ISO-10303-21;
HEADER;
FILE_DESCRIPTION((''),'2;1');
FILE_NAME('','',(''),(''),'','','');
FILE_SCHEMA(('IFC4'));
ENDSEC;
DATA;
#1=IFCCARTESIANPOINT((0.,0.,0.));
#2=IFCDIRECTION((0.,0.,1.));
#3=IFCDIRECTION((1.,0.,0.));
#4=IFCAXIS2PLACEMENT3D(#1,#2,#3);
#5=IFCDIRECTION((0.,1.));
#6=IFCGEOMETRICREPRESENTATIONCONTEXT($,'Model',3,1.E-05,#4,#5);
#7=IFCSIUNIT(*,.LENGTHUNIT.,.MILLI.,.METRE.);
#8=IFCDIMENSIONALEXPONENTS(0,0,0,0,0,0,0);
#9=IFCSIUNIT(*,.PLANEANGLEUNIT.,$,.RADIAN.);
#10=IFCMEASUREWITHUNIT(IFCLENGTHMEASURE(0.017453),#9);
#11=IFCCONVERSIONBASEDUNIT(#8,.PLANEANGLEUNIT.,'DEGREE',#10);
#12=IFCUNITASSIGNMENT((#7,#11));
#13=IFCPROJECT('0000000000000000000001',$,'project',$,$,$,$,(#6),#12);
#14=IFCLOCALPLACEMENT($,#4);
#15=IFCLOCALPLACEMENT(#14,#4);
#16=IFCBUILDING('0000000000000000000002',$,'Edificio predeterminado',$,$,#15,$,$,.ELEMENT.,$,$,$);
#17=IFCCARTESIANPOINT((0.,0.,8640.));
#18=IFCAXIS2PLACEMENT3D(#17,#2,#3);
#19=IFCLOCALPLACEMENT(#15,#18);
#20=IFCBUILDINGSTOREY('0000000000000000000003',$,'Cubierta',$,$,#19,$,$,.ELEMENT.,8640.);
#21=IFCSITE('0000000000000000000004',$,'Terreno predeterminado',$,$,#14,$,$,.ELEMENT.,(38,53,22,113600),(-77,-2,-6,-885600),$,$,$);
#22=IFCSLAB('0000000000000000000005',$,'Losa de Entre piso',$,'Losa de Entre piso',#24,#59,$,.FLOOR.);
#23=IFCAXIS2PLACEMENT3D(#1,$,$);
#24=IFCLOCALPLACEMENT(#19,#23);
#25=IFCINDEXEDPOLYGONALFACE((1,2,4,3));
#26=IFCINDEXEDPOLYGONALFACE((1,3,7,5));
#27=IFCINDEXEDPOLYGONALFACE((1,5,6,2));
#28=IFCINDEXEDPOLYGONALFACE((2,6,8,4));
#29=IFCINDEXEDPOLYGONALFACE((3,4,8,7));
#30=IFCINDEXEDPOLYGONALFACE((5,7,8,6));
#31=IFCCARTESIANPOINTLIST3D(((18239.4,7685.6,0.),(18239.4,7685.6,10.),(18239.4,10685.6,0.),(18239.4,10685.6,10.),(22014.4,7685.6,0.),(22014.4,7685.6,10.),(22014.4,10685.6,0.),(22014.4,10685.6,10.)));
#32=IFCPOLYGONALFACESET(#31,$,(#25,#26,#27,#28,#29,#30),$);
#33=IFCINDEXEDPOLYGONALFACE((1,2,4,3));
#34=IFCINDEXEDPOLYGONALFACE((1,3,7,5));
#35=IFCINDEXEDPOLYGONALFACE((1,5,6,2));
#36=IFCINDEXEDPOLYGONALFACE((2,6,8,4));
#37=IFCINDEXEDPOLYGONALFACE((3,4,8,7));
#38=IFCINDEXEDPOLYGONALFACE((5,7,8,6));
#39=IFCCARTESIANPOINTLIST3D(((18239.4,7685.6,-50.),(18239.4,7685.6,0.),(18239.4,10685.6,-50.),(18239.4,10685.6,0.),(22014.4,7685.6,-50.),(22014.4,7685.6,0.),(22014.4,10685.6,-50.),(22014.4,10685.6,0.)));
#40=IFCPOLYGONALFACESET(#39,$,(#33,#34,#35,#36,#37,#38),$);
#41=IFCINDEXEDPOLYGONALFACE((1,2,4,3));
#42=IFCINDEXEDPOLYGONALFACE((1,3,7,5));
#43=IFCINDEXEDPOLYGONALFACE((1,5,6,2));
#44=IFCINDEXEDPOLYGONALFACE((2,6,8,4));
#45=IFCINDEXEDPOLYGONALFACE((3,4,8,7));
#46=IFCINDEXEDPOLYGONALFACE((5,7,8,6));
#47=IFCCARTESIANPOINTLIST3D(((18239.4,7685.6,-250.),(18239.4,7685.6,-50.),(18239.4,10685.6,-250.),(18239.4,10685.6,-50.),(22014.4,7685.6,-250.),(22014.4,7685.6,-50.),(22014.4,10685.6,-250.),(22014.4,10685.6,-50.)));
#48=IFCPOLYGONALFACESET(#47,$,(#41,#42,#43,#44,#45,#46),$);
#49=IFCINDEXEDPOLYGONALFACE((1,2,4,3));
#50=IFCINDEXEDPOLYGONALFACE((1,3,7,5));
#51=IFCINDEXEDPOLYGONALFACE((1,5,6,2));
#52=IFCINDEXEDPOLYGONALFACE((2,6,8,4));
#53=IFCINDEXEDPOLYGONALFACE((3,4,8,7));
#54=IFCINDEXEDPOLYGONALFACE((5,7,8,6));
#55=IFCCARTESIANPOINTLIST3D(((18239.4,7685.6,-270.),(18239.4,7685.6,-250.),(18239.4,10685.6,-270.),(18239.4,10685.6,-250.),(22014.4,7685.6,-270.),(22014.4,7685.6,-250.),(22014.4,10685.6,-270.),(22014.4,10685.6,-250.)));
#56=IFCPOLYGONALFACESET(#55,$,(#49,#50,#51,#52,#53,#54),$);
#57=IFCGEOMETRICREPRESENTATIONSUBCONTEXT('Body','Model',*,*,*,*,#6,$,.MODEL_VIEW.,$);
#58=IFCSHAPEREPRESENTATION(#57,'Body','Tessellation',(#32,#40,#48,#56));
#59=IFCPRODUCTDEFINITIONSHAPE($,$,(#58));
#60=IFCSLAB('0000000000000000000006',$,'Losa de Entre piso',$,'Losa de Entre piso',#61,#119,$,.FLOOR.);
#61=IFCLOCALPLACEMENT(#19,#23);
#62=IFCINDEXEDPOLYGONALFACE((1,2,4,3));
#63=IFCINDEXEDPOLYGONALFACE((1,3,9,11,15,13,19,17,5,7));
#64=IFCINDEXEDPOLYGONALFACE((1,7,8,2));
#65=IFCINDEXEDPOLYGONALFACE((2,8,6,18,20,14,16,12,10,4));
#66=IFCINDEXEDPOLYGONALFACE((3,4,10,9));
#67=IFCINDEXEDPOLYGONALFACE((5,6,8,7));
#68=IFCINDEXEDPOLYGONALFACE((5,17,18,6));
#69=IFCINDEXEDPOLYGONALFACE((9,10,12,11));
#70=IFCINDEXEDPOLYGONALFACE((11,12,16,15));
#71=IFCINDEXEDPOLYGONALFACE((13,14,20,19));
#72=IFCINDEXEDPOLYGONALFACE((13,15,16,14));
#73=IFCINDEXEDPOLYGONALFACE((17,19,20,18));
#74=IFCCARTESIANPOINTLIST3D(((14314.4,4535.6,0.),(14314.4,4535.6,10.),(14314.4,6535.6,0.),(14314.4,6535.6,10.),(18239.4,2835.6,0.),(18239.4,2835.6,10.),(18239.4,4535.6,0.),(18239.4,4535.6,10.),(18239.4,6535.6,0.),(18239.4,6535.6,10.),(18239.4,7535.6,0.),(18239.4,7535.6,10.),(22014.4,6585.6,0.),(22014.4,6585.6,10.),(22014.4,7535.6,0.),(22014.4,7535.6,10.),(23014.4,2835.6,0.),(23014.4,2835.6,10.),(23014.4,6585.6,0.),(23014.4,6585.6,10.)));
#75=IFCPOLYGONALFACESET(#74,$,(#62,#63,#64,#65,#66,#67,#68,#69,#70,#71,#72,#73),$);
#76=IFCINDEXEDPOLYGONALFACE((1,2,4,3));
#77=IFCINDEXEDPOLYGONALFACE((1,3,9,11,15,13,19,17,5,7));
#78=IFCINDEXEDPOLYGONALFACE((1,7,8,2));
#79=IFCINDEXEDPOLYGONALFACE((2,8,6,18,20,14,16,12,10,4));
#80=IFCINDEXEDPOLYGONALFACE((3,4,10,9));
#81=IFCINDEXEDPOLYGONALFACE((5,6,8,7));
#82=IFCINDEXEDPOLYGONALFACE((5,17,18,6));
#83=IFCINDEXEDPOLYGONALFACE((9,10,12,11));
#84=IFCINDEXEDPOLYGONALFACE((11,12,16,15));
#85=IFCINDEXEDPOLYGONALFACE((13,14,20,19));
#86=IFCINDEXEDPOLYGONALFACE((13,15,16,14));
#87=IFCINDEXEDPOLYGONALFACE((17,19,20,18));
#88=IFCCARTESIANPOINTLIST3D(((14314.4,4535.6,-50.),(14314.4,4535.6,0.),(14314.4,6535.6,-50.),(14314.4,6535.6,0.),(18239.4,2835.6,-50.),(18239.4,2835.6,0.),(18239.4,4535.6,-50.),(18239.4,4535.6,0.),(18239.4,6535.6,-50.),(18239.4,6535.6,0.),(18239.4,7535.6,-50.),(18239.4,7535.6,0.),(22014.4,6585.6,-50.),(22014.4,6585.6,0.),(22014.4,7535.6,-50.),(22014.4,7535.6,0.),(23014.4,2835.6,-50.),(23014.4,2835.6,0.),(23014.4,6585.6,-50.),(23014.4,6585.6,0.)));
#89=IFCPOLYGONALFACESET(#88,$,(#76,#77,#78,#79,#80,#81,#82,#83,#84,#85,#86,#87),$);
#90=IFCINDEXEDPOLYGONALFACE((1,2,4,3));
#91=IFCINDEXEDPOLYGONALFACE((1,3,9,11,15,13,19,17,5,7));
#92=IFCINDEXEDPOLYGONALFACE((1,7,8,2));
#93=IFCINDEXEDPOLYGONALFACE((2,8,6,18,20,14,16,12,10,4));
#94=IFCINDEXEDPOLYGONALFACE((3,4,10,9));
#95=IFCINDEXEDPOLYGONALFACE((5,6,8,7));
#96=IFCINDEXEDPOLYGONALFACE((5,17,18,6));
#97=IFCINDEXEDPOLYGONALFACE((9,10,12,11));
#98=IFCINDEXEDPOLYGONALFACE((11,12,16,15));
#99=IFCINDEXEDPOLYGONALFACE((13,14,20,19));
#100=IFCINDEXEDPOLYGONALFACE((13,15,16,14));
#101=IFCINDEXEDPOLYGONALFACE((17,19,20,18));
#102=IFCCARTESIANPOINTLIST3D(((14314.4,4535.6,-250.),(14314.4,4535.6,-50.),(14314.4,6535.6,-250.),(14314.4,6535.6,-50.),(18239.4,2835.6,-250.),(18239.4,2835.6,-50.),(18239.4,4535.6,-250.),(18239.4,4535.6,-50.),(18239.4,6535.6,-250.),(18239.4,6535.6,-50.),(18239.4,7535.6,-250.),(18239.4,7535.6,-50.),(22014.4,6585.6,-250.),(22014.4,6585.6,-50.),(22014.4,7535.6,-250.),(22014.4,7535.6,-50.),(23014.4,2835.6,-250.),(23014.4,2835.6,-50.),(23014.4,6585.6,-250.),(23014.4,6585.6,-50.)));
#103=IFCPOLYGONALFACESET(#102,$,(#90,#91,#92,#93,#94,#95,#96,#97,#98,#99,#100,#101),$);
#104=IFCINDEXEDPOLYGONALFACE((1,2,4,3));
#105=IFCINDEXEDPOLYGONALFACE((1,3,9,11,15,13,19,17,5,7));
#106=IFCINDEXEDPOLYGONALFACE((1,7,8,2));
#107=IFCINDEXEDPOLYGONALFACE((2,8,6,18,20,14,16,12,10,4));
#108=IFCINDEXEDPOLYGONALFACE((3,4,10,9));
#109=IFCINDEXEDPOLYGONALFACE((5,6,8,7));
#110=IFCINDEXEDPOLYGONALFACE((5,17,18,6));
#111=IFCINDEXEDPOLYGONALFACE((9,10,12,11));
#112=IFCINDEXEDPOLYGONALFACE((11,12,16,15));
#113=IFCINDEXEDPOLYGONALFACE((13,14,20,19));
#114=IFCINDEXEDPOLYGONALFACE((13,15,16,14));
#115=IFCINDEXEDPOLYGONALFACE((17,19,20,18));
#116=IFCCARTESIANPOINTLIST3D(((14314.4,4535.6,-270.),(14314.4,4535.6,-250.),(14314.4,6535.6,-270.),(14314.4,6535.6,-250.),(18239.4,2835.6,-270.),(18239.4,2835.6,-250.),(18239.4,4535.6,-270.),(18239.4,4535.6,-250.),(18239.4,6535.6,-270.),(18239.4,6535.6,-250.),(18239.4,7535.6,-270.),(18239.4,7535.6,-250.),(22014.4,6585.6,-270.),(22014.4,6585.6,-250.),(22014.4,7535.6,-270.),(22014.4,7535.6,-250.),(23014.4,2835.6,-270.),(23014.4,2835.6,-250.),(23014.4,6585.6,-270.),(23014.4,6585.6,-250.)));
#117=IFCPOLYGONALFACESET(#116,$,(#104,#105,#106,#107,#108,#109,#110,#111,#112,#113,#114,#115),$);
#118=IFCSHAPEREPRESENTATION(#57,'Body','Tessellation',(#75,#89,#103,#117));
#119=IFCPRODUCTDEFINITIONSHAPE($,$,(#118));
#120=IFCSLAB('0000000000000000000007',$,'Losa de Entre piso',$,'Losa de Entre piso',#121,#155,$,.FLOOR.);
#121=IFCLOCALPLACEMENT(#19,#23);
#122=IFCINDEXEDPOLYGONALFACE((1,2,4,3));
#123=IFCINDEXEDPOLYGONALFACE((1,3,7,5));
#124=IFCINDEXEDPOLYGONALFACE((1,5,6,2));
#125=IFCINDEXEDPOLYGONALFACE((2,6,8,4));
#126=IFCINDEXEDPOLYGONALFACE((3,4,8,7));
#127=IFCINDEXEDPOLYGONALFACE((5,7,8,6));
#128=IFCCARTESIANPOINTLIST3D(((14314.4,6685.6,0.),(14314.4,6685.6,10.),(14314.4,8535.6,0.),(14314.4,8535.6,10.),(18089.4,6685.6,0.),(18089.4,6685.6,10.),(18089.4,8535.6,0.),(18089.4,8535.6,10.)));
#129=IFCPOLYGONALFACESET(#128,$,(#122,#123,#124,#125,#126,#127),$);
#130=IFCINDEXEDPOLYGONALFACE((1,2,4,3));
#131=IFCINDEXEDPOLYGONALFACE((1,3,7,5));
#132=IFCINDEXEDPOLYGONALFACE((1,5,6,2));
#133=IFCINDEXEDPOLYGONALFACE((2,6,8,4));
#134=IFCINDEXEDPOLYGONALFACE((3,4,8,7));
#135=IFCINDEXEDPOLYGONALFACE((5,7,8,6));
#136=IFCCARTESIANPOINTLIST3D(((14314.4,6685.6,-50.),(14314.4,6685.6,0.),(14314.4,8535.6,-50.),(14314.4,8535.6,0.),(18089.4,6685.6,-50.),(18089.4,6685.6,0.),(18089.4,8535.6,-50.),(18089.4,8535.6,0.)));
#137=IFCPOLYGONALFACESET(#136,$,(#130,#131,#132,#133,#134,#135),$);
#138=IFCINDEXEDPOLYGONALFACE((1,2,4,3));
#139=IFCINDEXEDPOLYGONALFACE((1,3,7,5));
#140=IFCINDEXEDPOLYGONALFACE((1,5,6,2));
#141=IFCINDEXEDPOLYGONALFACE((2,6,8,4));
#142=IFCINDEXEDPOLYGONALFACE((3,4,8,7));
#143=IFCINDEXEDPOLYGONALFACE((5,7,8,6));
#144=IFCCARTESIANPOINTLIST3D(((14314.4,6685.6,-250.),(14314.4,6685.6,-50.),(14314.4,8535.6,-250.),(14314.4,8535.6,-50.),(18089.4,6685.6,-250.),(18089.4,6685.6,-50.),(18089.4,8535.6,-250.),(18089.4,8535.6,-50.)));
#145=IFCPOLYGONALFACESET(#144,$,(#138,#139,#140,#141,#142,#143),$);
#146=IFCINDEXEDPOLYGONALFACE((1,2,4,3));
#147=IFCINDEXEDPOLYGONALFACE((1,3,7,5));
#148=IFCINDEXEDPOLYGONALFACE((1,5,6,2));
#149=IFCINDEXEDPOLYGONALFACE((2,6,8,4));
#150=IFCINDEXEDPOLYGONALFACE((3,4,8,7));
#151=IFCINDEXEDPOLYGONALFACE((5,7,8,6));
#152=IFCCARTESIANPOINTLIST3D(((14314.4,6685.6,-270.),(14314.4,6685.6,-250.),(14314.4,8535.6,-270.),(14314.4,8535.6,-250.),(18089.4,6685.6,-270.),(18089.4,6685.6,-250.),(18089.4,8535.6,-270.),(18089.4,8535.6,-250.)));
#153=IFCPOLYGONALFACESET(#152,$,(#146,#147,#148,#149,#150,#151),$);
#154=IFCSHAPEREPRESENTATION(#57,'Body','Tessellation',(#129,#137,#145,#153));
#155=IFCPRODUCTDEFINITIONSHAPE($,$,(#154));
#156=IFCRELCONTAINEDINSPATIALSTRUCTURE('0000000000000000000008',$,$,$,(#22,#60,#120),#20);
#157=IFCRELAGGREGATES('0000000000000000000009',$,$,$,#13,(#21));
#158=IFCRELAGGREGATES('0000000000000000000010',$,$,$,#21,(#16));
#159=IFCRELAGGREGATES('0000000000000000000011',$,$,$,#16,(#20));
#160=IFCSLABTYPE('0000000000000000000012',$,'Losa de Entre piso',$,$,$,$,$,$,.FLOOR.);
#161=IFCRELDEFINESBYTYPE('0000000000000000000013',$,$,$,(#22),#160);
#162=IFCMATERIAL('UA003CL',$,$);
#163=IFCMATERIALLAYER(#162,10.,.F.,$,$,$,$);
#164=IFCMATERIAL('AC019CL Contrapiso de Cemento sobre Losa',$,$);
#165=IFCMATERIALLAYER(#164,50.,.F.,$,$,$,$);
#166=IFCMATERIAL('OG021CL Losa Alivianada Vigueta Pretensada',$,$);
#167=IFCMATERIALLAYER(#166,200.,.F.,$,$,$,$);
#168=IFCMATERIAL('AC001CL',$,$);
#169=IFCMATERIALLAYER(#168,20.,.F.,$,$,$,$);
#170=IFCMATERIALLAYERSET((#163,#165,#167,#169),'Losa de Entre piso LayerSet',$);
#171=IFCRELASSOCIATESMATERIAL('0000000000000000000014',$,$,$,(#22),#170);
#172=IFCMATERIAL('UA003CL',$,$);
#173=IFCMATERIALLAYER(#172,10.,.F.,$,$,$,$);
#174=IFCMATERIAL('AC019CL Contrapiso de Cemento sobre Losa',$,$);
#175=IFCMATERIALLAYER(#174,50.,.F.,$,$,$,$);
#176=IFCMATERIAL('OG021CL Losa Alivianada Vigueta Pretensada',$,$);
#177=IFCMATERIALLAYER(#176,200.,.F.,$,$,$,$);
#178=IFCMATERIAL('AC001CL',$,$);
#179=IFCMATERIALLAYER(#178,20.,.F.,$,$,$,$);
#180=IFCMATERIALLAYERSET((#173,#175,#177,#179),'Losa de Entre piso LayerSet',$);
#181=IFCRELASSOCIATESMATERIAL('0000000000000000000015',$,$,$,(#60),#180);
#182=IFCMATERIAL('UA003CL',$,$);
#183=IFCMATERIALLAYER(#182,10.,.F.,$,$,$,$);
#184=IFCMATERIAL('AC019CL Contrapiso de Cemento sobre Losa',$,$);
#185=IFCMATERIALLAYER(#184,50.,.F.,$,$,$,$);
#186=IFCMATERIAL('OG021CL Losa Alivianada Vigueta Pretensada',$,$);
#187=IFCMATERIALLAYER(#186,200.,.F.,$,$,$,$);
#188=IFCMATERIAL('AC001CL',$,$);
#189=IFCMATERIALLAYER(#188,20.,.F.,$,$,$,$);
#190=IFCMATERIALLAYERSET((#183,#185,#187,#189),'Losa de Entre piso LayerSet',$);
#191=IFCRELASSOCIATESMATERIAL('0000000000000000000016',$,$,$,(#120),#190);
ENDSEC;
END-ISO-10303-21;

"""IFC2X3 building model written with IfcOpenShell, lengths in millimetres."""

from ifc_helpers import new_model, entity, si_unit, converted_unit, direction, frame, origin_with_axes, place, context, subcontext, project, spatial, polyline, outline, extrude, material, layer, layer_set, layer_usage, type_object, element, save


model = new_model("IFC2X3")

# Units and contexts
model_context = context("Model", 3, precision=1e-05, world=origin_with_axes(), true_north=direction((0.0, 1.0)))
body_context = subcontext(model_context, "Body", "Model", "MODEL_VIEW")
ifc_project = project(units=[si_unit("LENGTHUNIT", "METRE", prefix="MILLI"), converted_unit("PLANEANGLEUNIT", "DEGREE", entity("IfcLengthMeasure", 0.017453), si_unit("PLANEANGLEUNIT", "RADIAN"), dimensions=[0, 0, 0, 0, 0, 0, 0])], contexts=[model_context])

# Site, building, storey
site_placement = place(None, origin_with_axes())
site = spatial("IfcSite", under=ifc_project, at=site_placement, Name="Terreno predeterminado", CompositionType="ELEMENT", RefLatitude=(38, 53, 22, 113600), RefLongitude=(-77, -2, -6, -885600))
building_placement = place(site_placement, origin_with_axes())
building = spatial("IfcBuilding", under=site, at=building_placement, Name="Edificio predeterminado", CompositionType="ELEMENT")
storey_placement = place(building_placement, frame((0.0, 0.0, 8640.0), z_axis=(0.0, 0.0, 1.0), x_axis=(1.0, 0.0, 0.0)))
storey = spatial("IfcBuildingStorey", under=building, at=storey_placement, Name="Cubierta", CompositionType="ELEMENT", Elevation=8640.0)

# Slabs
ifc_material_1 = material(Name="UA003CL")
ifc_layer_1 = layer(ifc_material_1, 10.0, ventilated=False)
ifc_material_2 = material(Name="AC019CL Contrapiso de Cemento sobre Losa")
ifc_layer_2 = layer(ifc_material_2, 50.0, ventilated=False)
ifc_material_3 = material(Name="OG021CL Losa Alivianada Vigueta Pretensada")
ifc_layer_3 = layer(ifc_material_3, 200.0, ventilated=False)
ifc_material_4 = material(Name="AC001CL")
ifc_layer_4 = layer(ifc_material_4, 20.0, ventilated=False)
ifc_layer_set_1 = layer_set([ifc_layer_1, ifc_layer_2, ifc_layer_3, ifc_layer_4], Name="Losa de Entre piso LayerSet")
ifc_layer_usage_1 = layer_usage(ifc_layer_set_1, "AXIS3", "NEGATIVE", 0.0)
slab_type = type_object("IfcSlabType", Name="Losa de Entre piso", PredefinedType="FLOOR")
slab_1_placement = place(storey_placement, frame((0.0, 0.0, -8640.0), z_axis=(0.0, 0.0, 1.0), x_axis=(1.0, 0.0, 0.0)))
element("IfcSlab", 1, at=slab_1_placement, inside=storey, type_object=slab_type, material=ifc_layer_usage_1, Name="Losa de Entre piso", ObjectType="Losa de Entre piso", PredefinedType="FLOOR", context=body_context, shape_type="SweptSolid", body=[
    extrude(outline(polyline([(0.0, 3000.0), (3775.0, 3000.0), (3775.0, 0.0), (0.0, 0.0), (0.0, 3000.0)])), frame((22014.4, 7685.6, 8640.0), z_axis=(0.0, 0.0, -1.0), x_axis=(-1.0, 0.0, 0.0)), (0.0, 0.0, -1.0), 10.0),
    extrude(outline(polyline([(0.0, 3000.0), (3775.0, 3000.0), (3775.0, 0.0), (0.0, 0.0), (0.0, 3000.0)])), frame((22014.4, 7685.6, 8590.0), z_axis=(0.0, 0.0, -1.0), x_axis=(-1.0, 0.0, 0.0)), (0.0, 0.0, -1.0), 50.0),
    extrude(outline(polyline([(0.0, 3000.0), (3775.0, 3000.0), (3775.0, 0.0), (0.0, 0.0), (0.0, 3000.0)])), frame((22014.4, 7685.6, 8390.0), z_axis=(0.0, 0.0, -1.0), x_axis=(-1.0, 0.0, 0.0)), (0.0, 0.0, -1.0), 200.0),
    extrude(outline(polyline([(0.0, 3000.0), (3775.0, 3000.0), (3775.0, 0.0), (0.0, 0.0), (0.0, 3000.0)])), frame((22014.4, 7685.6, 8370.0), z_axis=(0.0, 0.0, -1.0), x_axis=(-1.0, 0.0, 0.0)), (0.0, 0.0, -1.0), 20.0),
])
ifc_material_5 = material(Name="UA003CL")
ifc_layer_5 = layer(ifc_material_5, 10.0, ventilated=False)
ifc_material_6 = material(Name="AC019CL Contrapiso de Cemento sobre Losa")
ifc_layer_6 = layer(ifc_material_6, 50.0, ventilated=False)
ifc_material_7 = material(Name="OG021CL Losa Alivianada Vigueta Pretensada")
ifc_layer_7 = layer(ifc_material_7, 200.0, ventilated=False)
ifc_material_8 = material(Name="AC001CL")
ifc_layer_8 = layer(ifc_material_8, 20.0, ventilated=False)
ifc_layer_set_2 = layer_set([ifc_layer_5, ifc_layer_6, ifc_layer_7, ifc_layer_8], Name="Losa de Entre piso LayerSet")
ifc_layer_usage_2 = layer_usage(ifc_layer_set_2, "AXIS3", "NEGATIVE", 0.0)
slab_2_placement = place(storey_placement, frame((0.0, 0.0, -8640.0), z_axis=(0.0, 0.0, 1.0), x_axis=(1.0, 0.0, 0.0)))
element("IfcSlab", 2, at=slab_2_placement, inside=storey, material=ifc_layer_usage_2, Name="Losa de Entre piso", ObjectType="Losa de Entre piso", PredefinedType="FLOOR", context=body_context, shape_type="SweptSolid", body=[
    extrude(outline(polyline([(0.0, 1000.0), (-3925.0, 1000.0), (-3925.0, 3000.0), (0.0, 3000.0), (0.0, 4700.0), (4775.0, 4700.0), (4775.0, 950.0), (3775.0, 950.0), (3775.0, 0.0), (0.0, 0.0), (0.0, 1000.0)])), frame((18239.4, 7535.6, 8640.0), z_axis=(0.0, 0.0, -1.0), x_axis=(1.0, 0.0, 0.0)), (0.0, 0.0, -1.0), 10.0),
    extrude(outline(polyline([(0.0, 1000.0), (-3925.0, 1000.0), (-3925.0, 3000.0), (0.0, 3000.0), (0.0, 4700.0), (4775.0, 4700.0), (4775.0, 950.0), (3775.0, 950.0), (3775.0, 0.0), (0.0, 0.0), (0.0, 1000.0)])), frame((18239.4, 7535.6, 8590.0), z_axis=(0.0, 0.0, -1.0), x_axis=(1.0, 0.0, 0.0)), (0.0, 0.0, -1.0), 50.0),
    extrude(outline(polyline([(0.0, 1000.0), (-3925.0, 1000.0), (-3925.0, 3000.0), (0.0, 3000.0), (0.0, 4700.0), (4775.0, 4700.0), (4775.0, 950.0), (3775.0, 950.0), (3775.0, 0.0), (0.0, 0.0), (0.0, 1000.0)])), frame((18239.4, 7535.6, 8390.0), z_axis=(0.0, 0.0, -1.0), x_axis=(1.0, 0.0, 0.0)), (0.0, 0.0, -1.0), 200.0),
    extrude(outline(polyline([(0.0, 1000.0), (-3925.0, 1000.0), (-3925.0, 3000.0), (0.0, 3000.0), (0.0, 4700.0), (4775.0, 4700.0), (4775.0, 950.0), (3775.0, 950.0), (3775.0, 0.0), (0.0, 0.0), (0.0, 1000.0)])), frame((18239.4, 7535.6, 8370.0), z_axis=(0.0, 0.0, -1.0), x_axis=(1.0, 0.0, 0.0)), (0.0, 0.0, -1.0), 20.0),
])
ifc_material_9 = material(Name="UA003CL")
ifc_layer_9 = layer(ifc_material_9, 10.0, ventilated=False)
ifc_material_10 = material(Name="AC019CL Contrapiso de Cemento sobre Losa")
ifc_layer_10 = layer(ifc_material_10, 50.0, ventilated=False)
ifc_material_11 = material(Name="OG021CL Losa Alivianada Vigueta Pretensada")
ifc_layer_11 = layer(ifc_material_11, 200.0, ventilated=False)
ifc_material_12 = material(Name="AC001CL")
ifc_layer_12 = layer(ifc_material_12, 20.0, ventilated=False)
ifc_layer_set_3 = layer_set([ifc_layer_9, ifc_layer_10, ifc_layer_11, ifc_layer_12], Name="Losa de Entre piso LayerSet")
ifc_layer_usage_3 = layer_usage(ifc_layer_set_3, "AXIS3", "NEGATIVE", 0.0)
slab_3_placement = place(storey_placement, frame((0.0, 0.0, -8640.0), z_axis=(0.0, 0.0, 1.0), x_axis=(1.0, 0.0, 0.0)))
element("IfcSlab", 3, at=slab_3_placement, inside=storey, material=ifc_layer_usage_3, Name="Losa de Entre piso", ObjectType="Losa de Entre piso", PredefinedType="FLOOR", context=body_context, shape_type="SweptSolid", body=[
    extrude(outline(polyline([(0.0, 1850.0), (3775.0, 1850.0), (3775.0, 0.0), (0.0, 0.0), (0.0, 1850.0)])), frame((18089.4, 6685.6, 8640.0), z_axis=(0.0, 0.0, -1.0), x_axis=(-1.0, 0.0, 0.0)), (0.0, 0.0, -1.0), 10.0),
    extrude(outline(polyline([(0.0, 1850.0), (3775.0, 1850.0), (3775.0, 0.0), (0.0, 0.0), (0.0, 1850.0)])), frame((18089.4, 6685.6, 8590.0), z_axis=(0.0, 0.0, -1.0), x_axis=(-1.0, 0.0, 0.0)), (0.0, 0.0, -1.0), 50.0),
    extrude(outline(polyline([(0.0, 1850.0), (3775.0, 1850.0), (3775.0, 0.0), (0.0, 0.0), (0.0, 1850.0)])), frame((18089.4, 6685.6, 8390.0), z_axis=(0.0, 0.0, -1.0), x_axis=(-1.0, 0.0, 0.0)), (0.0, 0.0, -1.0), 200.0),
    extrude(outline(polyline([(0.0, 1850.0), (3775.0, 1850.0), (3775.0, 0.0), (0.0, 0.0), (0.0, 1850.0)])), frame((18089.4, 6685.6, 8370.0), z_axis=(0.0, 0.0, -1.0), x_axis=(-1.0, 0.0, 0.0)), (0.0, 0.0, -1.0), 20.0),
])

save(model, "model.ifc")
